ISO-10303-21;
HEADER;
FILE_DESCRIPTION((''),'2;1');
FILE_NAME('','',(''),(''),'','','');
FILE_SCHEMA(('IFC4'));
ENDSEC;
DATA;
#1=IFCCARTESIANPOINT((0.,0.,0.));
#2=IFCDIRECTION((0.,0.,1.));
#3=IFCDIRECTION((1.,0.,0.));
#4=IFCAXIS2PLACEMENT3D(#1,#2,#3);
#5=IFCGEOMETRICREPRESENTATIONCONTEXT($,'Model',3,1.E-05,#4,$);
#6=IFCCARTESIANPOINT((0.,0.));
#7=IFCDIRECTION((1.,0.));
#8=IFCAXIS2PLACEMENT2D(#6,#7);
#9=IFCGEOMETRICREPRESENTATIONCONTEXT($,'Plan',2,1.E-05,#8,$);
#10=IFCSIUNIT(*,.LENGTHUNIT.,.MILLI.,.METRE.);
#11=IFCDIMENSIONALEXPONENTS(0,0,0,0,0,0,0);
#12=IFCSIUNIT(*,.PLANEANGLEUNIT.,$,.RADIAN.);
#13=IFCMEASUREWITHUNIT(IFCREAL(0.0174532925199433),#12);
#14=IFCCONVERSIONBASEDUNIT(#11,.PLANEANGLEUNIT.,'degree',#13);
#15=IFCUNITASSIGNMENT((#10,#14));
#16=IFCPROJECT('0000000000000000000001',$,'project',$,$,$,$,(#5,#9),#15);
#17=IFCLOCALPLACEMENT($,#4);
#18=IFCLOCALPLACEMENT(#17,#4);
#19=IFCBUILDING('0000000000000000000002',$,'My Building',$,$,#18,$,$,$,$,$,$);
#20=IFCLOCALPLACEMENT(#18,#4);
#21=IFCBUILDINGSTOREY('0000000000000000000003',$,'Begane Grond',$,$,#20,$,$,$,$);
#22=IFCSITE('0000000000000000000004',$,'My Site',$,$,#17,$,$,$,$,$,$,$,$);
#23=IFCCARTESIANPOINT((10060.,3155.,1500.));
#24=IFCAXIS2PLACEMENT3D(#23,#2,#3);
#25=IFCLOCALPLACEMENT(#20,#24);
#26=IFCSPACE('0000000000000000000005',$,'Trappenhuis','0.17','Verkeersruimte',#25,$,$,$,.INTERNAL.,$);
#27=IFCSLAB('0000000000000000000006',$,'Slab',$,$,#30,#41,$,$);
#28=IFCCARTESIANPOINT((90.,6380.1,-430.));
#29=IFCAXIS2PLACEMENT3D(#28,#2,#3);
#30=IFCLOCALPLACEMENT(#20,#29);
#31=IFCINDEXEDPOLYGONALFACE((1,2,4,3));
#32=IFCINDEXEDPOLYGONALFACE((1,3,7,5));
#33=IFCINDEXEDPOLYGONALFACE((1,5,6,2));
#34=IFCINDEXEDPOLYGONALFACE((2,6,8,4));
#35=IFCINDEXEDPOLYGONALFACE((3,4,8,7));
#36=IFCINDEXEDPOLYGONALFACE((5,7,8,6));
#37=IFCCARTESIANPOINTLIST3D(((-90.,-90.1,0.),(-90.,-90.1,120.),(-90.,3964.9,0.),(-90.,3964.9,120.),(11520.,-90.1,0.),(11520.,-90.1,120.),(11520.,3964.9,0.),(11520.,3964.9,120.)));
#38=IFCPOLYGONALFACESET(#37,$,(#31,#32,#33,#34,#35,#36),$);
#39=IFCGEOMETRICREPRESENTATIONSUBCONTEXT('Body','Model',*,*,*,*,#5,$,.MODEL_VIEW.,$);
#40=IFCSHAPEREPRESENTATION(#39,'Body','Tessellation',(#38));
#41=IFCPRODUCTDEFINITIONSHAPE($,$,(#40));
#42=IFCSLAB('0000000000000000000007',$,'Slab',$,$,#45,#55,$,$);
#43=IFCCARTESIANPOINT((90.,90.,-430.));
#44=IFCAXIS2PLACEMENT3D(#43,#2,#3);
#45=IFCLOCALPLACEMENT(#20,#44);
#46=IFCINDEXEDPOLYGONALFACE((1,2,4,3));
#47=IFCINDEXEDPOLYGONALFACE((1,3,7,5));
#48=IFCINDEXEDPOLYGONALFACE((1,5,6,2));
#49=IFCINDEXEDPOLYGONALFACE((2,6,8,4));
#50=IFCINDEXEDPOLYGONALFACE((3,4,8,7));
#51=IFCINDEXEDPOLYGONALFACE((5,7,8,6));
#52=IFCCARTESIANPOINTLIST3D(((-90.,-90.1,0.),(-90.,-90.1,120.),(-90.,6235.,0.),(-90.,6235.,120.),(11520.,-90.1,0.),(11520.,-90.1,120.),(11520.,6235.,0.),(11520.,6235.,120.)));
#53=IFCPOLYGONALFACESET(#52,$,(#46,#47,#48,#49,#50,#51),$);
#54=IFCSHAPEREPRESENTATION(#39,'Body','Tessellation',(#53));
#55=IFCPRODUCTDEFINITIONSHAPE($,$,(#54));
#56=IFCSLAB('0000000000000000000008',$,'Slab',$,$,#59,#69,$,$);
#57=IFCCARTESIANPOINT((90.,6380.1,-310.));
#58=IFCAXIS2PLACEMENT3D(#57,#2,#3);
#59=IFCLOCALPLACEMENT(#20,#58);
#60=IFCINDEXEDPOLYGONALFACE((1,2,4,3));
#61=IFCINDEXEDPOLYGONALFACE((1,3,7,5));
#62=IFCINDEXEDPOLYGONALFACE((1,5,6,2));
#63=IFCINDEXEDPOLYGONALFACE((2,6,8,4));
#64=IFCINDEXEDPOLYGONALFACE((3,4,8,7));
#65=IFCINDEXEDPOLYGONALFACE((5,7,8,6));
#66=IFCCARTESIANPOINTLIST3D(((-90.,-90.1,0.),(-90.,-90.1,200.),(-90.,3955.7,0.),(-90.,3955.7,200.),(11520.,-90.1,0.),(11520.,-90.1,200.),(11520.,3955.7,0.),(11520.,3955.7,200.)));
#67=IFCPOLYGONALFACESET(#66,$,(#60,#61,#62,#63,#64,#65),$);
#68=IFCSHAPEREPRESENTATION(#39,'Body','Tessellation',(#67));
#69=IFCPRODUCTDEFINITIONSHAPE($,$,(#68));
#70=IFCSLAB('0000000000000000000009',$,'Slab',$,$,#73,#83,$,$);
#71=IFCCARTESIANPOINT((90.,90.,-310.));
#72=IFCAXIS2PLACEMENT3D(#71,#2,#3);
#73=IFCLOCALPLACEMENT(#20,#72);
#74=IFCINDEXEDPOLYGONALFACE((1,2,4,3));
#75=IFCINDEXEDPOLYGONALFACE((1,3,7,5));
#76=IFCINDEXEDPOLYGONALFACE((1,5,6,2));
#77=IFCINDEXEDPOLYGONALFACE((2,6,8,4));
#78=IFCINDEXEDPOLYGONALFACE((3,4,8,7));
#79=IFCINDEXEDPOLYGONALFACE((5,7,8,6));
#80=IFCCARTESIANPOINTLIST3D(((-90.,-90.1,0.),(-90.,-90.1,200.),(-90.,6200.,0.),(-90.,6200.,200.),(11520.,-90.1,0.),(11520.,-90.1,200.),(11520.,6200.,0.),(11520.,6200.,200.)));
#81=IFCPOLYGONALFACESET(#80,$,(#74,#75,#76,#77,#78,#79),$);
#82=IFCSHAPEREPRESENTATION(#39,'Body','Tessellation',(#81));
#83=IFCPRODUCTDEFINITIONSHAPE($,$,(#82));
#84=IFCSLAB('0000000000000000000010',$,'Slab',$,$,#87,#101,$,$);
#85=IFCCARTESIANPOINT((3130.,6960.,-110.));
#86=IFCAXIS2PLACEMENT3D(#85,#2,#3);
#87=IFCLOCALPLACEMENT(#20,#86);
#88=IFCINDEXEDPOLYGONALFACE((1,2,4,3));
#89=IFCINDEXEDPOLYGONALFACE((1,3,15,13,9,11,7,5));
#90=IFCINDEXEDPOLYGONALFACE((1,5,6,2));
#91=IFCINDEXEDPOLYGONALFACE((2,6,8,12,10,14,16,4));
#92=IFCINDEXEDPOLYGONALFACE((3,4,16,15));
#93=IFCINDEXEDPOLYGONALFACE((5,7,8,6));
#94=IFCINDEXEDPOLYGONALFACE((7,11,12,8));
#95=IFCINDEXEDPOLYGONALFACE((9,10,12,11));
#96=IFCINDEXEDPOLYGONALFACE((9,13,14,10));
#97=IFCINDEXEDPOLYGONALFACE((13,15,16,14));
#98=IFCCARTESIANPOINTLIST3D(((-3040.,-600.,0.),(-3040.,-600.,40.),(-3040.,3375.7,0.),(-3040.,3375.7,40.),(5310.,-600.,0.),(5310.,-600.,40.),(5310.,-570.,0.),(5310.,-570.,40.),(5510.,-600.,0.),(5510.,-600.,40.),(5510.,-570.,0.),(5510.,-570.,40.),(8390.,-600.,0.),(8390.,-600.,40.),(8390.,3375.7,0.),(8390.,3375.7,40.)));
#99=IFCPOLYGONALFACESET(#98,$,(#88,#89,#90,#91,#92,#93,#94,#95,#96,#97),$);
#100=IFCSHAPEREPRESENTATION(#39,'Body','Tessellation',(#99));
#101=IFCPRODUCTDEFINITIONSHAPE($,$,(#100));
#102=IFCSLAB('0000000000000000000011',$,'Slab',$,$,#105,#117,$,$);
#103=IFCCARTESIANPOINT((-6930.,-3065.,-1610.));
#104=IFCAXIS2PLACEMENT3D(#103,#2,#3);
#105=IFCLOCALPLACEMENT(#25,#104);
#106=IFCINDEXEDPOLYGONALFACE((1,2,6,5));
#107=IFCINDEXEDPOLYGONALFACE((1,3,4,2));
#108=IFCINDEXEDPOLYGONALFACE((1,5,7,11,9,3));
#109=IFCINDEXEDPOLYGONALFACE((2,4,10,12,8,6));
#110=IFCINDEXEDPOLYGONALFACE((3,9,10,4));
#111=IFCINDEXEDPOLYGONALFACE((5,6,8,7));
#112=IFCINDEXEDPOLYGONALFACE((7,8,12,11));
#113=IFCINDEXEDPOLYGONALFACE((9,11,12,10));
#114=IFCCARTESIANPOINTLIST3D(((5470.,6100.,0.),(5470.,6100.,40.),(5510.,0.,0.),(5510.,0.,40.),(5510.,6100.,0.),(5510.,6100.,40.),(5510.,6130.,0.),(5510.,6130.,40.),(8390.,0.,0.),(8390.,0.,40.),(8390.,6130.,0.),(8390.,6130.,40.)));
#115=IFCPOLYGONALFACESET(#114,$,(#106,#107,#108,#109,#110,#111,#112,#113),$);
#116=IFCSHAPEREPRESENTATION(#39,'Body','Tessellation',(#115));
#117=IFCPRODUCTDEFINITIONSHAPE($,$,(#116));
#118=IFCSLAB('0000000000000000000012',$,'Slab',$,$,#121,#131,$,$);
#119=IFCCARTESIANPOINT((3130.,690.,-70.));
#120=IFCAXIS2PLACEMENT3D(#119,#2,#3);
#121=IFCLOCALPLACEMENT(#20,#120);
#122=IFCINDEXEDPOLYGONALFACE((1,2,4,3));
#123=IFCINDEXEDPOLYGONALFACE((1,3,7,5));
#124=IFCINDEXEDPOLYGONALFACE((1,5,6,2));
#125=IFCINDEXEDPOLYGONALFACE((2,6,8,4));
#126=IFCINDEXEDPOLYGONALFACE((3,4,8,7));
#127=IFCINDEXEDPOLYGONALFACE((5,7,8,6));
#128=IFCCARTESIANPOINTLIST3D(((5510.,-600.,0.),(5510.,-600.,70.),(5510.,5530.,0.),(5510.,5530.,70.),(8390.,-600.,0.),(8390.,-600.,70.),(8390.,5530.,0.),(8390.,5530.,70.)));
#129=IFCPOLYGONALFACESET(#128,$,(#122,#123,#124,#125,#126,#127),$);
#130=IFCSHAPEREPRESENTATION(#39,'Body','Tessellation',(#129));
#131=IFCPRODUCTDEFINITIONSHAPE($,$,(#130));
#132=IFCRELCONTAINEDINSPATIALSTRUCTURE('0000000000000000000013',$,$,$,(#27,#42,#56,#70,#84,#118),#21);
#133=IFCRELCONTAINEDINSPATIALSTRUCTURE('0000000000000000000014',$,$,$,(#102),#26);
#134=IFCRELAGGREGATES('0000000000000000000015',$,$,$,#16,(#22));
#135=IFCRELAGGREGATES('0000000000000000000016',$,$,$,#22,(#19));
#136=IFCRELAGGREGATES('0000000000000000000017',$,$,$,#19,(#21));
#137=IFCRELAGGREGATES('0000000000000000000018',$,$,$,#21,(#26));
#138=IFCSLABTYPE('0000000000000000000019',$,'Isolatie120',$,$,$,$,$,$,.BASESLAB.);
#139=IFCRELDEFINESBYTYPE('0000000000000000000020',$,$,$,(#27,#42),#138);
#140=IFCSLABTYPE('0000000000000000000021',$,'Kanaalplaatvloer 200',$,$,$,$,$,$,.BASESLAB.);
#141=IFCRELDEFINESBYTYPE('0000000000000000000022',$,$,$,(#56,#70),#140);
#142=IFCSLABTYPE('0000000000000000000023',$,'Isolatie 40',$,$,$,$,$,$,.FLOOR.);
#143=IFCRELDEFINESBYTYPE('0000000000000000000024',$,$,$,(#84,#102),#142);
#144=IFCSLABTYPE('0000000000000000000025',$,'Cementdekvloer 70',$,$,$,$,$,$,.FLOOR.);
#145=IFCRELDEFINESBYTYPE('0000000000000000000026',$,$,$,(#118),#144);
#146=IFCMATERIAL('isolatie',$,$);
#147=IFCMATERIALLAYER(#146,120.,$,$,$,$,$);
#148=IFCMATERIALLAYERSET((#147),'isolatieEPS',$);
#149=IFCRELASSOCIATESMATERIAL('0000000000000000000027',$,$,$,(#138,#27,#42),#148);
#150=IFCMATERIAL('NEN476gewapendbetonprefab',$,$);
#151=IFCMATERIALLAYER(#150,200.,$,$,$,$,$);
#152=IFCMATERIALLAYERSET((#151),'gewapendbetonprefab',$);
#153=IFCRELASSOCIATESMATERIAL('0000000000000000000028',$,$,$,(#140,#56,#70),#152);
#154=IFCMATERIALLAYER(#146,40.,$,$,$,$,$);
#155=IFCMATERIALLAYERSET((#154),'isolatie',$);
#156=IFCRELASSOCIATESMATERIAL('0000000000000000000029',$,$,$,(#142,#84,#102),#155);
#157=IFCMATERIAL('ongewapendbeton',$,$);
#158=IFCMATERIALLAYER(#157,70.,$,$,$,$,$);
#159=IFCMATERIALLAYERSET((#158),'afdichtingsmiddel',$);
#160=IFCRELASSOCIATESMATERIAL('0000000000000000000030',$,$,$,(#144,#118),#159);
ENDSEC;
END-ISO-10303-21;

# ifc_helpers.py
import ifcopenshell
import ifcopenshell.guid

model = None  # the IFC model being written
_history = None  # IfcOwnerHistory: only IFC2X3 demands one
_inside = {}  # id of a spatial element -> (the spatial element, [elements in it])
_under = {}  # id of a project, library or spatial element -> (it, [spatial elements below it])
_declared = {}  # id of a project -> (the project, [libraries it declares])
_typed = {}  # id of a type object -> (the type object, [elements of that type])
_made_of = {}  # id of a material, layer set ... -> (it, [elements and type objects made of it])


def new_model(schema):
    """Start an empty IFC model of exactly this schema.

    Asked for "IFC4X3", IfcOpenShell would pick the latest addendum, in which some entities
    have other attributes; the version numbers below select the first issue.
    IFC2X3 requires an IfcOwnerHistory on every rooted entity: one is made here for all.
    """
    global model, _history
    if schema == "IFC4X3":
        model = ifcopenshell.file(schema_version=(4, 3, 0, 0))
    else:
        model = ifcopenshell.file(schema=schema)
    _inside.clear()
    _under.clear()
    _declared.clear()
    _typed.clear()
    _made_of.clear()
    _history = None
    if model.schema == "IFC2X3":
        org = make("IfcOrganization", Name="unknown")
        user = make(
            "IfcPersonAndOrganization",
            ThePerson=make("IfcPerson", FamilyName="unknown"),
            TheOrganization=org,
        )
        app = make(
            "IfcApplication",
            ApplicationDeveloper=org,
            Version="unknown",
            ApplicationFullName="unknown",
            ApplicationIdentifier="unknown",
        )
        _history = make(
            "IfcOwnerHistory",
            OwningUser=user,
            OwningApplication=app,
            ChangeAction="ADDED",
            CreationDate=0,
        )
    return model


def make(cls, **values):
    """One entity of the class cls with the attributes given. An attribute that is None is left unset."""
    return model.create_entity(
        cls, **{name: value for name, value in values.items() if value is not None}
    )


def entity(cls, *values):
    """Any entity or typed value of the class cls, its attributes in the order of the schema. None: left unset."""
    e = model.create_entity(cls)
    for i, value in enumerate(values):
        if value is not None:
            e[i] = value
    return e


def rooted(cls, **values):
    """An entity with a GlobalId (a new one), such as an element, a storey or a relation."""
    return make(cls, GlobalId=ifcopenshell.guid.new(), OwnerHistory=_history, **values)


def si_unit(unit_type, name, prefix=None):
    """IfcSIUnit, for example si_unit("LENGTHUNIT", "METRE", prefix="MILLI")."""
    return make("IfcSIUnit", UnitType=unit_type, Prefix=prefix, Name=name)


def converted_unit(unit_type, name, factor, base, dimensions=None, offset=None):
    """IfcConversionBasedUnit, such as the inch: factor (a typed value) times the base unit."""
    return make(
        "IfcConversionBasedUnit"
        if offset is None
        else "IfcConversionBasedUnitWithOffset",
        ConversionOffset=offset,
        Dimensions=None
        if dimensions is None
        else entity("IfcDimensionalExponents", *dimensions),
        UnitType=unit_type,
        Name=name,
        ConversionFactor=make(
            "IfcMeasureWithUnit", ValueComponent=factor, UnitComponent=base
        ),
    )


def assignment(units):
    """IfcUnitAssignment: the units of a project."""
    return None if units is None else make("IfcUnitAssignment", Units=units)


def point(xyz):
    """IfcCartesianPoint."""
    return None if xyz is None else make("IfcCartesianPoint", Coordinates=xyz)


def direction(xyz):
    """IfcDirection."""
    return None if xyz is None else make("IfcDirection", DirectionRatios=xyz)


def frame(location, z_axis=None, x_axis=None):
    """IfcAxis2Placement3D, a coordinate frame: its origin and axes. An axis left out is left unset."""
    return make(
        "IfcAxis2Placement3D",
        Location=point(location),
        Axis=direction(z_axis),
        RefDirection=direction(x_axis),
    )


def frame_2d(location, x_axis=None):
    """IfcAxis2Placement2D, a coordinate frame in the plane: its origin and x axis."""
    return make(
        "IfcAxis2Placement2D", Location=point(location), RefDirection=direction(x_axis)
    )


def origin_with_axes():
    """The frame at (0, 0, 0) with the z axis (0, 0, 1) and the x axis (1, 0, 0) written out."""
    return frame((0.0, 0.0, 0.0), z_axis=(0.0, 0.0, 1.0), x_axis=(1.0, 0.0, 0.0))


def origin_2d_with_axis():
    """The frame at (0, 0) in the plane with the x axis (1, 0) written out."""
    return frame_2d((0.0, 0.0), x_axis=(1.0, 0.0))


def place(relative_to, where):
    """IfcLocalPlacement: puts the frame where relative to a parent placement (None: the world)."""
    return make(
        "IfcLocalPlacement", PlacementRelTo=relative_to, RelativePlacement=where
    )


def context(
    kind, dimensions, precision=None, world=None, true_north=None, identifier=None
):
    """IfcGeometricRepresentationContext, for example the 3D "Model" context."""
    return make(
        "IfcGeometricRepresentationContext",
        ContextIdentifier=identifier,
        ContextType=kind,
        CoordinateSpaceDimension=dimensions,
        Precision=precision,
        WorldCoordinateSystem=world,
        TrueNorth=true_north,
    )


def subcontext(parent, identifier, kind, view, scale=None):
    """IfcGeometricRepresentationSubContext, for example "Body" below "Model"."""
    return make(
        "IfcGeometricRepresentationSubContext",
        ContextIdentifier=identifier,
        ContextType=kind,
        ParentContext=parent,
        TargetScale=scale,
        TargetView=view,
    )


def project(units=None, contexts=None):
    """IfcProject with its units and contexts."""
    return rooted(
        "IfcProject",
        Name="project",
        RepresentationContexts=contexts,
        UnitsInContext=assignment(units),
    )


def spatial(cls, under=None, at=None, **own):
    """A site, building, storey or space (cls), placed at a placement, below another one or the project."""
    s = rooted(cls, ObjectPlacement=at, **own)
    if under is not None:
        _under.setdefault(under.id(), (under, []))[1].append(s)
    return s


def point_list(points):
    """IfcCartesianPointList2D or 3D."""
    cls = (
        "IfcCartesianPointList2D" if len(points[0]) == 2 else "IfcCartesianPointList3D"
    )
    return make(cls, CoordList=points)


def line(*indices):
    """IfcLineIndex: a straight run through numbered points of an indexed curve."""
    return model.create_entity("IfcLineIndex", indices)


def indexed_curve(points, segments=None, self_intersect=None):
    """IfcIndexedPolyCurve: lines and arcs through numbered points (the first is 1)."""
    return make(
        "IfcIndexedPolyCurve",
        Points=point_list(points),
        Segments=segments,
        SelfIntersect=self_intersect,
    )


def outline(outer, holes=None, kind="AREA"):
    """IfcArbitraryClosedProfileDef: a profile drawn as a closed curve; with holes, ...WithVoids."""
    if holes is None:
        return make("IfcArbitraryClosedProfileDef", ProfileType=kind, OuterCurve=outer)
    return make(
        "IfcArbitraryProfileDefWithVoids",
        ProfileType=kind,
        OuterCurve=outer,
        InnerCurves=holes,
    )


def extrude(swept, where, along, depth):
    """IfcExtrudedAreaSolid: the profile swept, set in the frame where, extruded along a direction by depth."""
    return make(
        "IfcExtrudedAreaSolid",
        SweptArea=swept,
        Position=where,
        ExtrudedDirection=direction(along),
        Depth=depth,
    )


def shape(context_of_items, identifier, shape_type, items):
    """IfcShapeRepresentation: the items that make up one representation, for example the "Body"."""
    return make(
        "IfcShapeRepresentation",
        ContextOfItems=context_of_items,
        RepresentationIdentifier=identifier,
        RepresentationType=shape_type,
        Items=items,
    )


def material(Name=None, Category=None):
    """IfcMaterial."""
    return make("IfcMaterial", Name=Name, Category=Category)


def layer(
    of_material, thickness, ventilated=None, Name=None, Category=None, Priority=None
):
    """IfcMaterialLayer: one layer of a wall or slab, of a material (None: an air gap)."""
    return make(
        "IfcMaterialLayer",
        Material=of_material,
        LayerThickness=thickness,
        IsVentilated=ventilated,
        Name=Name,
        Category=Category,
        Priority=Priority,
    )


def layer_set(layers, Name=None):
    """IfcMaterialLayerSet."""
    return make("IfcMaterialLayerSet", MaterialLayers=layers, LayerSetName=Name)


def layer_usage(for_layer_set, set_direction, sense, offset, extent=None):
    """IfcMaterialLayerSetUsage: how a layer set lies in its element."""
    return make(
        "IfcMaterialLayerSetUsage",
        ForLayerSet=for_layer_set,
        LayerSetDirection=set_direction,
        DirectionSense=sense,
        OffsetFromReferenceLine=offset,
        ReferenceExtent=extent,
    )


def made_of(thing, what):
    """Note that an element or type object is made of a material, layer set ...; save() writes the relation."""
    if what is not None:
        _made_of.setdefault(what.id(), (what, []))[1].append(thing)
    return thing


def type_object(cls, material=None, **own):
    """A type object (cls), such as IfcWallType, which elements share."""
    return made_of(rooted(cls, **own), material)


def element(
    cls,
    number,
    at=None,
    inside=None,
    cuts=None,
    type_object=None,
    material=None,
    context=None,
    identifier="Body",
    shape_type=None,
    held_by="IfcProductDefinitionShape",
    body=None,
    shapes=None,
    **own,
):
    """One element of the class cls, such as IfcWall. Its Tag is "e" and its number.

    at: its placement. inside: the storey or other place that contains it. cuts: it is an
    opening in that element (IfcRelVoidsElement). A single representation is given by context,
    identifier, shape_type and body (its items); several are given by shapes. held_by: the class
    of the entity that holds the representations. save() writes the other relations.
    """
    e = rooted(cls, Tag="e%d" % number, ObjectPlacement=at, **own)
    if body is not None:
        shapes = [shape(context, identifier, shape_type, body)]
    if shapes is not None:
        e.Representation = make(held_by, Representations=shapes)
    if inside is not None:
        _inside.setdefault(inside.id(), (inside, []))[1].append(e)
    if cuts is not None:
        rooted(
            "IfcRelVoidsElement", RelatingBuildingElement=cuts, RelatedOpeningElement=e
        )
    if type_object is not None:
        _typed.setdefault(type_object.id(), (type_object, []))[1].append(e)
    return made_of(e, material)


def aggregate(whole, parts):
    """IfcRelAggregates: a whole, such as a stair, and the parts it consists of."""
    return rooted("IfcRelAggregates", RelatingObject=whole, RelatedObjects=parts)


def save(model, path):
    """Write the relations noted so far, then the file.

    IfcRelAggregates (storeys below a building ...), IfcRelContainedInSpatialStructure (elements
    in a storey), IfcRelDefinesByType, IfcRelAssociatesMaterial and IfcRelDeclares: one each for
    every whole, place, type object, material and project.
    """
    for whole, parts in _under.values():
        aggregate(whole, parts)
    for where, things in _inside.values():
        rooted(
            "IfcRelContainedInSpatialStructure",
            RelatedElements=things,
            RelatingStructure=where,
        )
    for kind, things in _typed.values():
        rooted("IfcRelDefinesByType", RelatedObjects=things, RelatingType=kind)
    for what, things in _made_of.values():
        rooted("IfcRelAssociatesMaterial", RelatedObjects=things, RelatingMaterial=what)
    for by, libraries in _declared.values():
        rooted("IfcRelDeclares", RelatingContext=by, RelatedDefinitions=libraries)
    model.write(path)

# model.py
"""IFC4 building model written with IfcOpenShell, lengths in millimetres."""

from ifc_helpers import new_model, entity, si_unit, converted_unit, frame, origin_with_axes, origin_2d_with_axis, place, context, subcontext, project, spatial, line, indexed_curve, outline, extrude, material, layer, layer_set, layer_usage, type_object, element, save


model = new_model("IFC4")

# Units and contexts
model_context = context("Model", 3, precision=1e-05, world=origin_with_axes())
plan_context = context("Plan", 2, precision=1e-05, world=origin_2d_with_axis())
body_context = subcontext(model_context, "Body", "Model", "MODEL_VIEW")
ifc_project = project(units=[si_unit("LENGTHUNIT", "METRE", prefix="MILLI"), converted_unit("PLANEANGLEUNIT", "degree", entity("IfcReal", 0.0174532925199433), si_unit("PLANEANGLEUNIT", "RADIAN"), dimensions=[0, 0, 0, 0, 0, 0, 0])], contexts=[model_context, plan_context])

# Site, building, storey
site_placement = place(None, origin_with_axes())
site = spatial("IfcSite", under=ifc_project, at=site_placement, Name="My Site")
building_placement = place(site_placement, origin_with_axes())
building = spatial("IfcBuilding", under=site, at=building_placement, Name="My Building")
storey_placement = place(building_placement, origin_with_axes())
storey = spatial("IfcBuildingStorey", under=building, at=storey_placement, Name="Begane Grond")

# Shared definitions
ifc_material_1 = material(Name="NEN476gewapendbetonprefab")

# Slabs
ifc_material_2 = material(Name="isolatie")
ifc_layer_1 = layer(ifc_material_2, 120.0)
ifc_layer_set_1 = layer_set([ifc_layer_1], Name="isolatieEPS")
ifc_layer_usage_1 = layer_usage(ifc_layer_set_1, "AXIS3", "POSITIVE", 0.0)
slab_type_1 = type_object("IfcSlabType", Name="Isolatie120", PredefinedType="BASESLAB", material=ifc_layer_set_1)
slab_1_placement = place(storey_placement, frame((90.0, 6380.1, -430.0), z_axis=(0.0, 0.0, 1.0), x_axis=(1.0, 0.0, 0.0)))
element("IfcSlab", 1, at=slab_1_placement, inside=storey, type_object=slab_type_1, material=ifc_layer_usage_1, Name="Slab", context=body_context, shape_type="SweptSolid", body=[
    extrude(outline(indexed_curve([(11520.0, 3964.9), (-90.0, 3964.9), (-90.0, -90.1), (11520.0, -90.1)], segments=[line(3, 2), line(2, 1), line(1, 4), line(4, 3)], self_intersect=False)), None, (0.0, 0.0, 1.0), 120.0),
])
ifc_layer_usage_2 = layer_usage(ifc_layer_set_1, "AXIS3", "POSITIVE", 0.0)
slab_2_placement = place(storey_placement, frame((90.0, 90.0, -430.0), z_axis=(0.0, 0.0, 1.0), x_axis=(1.0, 0.0, 0.0)))
element("IfcSlab", 2, at=slab_2_placement, inside=storey, type_object=slab_type_1, material=ifc_layer_usage_2, Name="Slab", context=body_context, shape_type="SweptSolid", body=[
    extrude(outline(indexed_curve([(11520.0, 6235.0), (-90.0, 6235.0), (-90.0, -90.1), (11520.0, -90.1)], segments=[line(4, 1), line(1, 2), line(2, 3), line(3, 4)], self_intersect=False)), None, (0.0, 0.0, 1.0), 120.0),
])
ifc_layer_2 = layer(ifc_material_1, 200.0)
ifc_layer_set_2 = layer_set([ifc_layer_2], Name="gewapendbetonprefab")
ifc_layer_usage_3 = layer_usage(ifc_layer_set_2, "AXIS3", "POSITIVE", 0.0)
slab_type_2 = type_object("IfcSlabType", Name="Kanaalplaatvloer 200", PredefinedType="BASESLAB", material=ifc_layer_set_2)
slab_3_placement = place(storey_placement, frame((90.0, 6380.1, -310.0), z_axis=(0.0, 0.0, 1.0), x_axis=(1.0, 0.0, 0.0)))
element("IfcSlab", 3, at=slab_3_placement, inside=storey, type_object=slab_type_2, material=ifc_layer_usage_3, Name="Slab", context=body_context, shape_type="SweptSolid", body=[
    extrude(outline(indexed_curve([(11520.0, 3955.7), (-90.0, 3955.7), (-90.0, -90.1), (11520.0, -90.1)], segments=[line(4, 1), line(1, 2), line(2, 3), line(3, 4)], self_intersect=False)), None, (0.0, 0.0, 1.0), 200.0),
])
ifc_layer_usage_4 = layer_usage(ifc_layer_set_2, "AXIS3", "POSITIVE", 0.0)
slab_4_placement = place(storey_placement, frame((90.0, 90.0, -310.0), z_axis=(0.0, 0.0, 1.0), x_axis=(1.0, 0.0, 0.0)))
element("IfcSlab", 4, at=slab_4_placement, inside=storey, type_object=slab_type_2, material=ifc_layer_usage_4, Name="Slab", context=body_context, shape_type="SweptSolid", body=[
    extrude(outline(indexed_curve([(-90.0, -90.1), (11520.0, -90.1), (11520.0, 6200.0), (-90.0, 6200.0)], segments=[line(4, 1), line(1, 2), line(2, 3), line(3, 4)], self_intersect=False)), None, (0.0, 0.0, 1.0), 200.0),
])
ifc_layer_3 = layer(ifc_material_2, 40.0)
ifc_layer_set_3 = layer_set([ifc_layer_3], Name="isolatie")
ifc_layer_usage_5 = layer_usage(ifc_layer_set_3, "AXIS3", "POSITIVE", 0.0)
slab_type_3 = type_object("IfcSlabType", Name="Isolatie 40", PredefinedType="FLOOR", material=ifc_layer_set_3)
slab_5_placement = place(storey_placement, frame((3130.0, 6960.0, -110.0), z_axis=(0.0, 0.0, 1.0), x_axis=(1.0, 0.0, 0.0)))
element("IfcSlab", 5, at=slab_5_placement, inside=storey, type_object=slab_type_3, material=ifc_layer_usage_5, Name="Slab", context=body_context, shape_type="SweptSolid", body=[
    extrude(outline(indexed_curve([(5310.0, -570.0), (5510.0, -570.0), (5510.0, -600.0), (8390.0, -600.0), (8390.0, 3375.7), (-3040.0, 3375.7), (-3040.0, -600.0), (5310.0, -600.0)], segments=[line(5, 6), line(6, 7), line(7, 8), line(8, 1), line(1, 2), line(2, 3), line(3, 4), line(4, 5)], self_intersect=False)), None, (0.0, 0.0, 1.0), 40.0),
])

# Shared definitions
space_1_placement = place(storey_placement, frame((10060.0, 3155.0, 1500.0), z_axis=(0.0, 0.0, 1.0), x_axis=(1.0, 0.0, 0.0)))
space_1 = spatial("IfcSpace", under=storey, at=space_1_placement, Name="Trappenhuis", Description="0.17", ObjectType="Verkeersruimte", PredefinedType="INTERNAL")

# Slabs
ifc_layer_usage_6 = layer_usage(ifc_layer_set_3, "AXIS3", "POSITIVE", 0.0)
slab_6_placement = place(space_1_placement, frame((-6930.0, -3065.0, -1610.0), z_axis=(0.0, 0.0, 1.0), x_axis=(1.0, 0.0, 0.0)))
element("IfcSlab", 6, at=slab_6_placement, inside=space_1, type_object=slab_type_3, material=ifc_layer_usage_6, Name="Slab", context=body_context, shape_type="SweptSolid", body=[
    extrude(outline(indexed_curve([(8390.0, 0.0), (5510.0, 0.0), (5510.0, 6130.0), (5470.0, 6100.0), (5510.0, 6100.0), (8390.0, 6130.0)], segments=[line(2, 1), line(1, 6), line(6, 3), line(3, 5), line(5, 4), line(4, 2)], self_intersect=False)), None, (0.0, 0.0, 1.0), 40.0),
])
ifc_material_3 = material(Name="ongewapendbeton")
ifc_layer_4 = layer(ifc_material_3, 70.0)
ifc_layer_set_4 = layer_set([ifc_layer_4], Name="afdichtingsmiddel")
ifc_layer_usage_7 = layer_usage(ifc_layer_set_4, "AXIS3", "POSITIVE", 0.0)
slab_type_4 = type_object("IfcSlabType", Name="Cementdekvloer 70", PredefinedType="FLOOR", material=ifc_layer_set_4)
slab_7_placement = place(storey_placement, frame((3130.0, 690.0, -70.0), z_axis=(0.0, 0.0, 1.0), x_axis=(1.0, 0.0, 0.0)))
element("IfcSlab", 7, at=slab_7_placement, inside=storey, type_object=slab_type_4, material=ifc_layer_usage_7, Name="Slab", context=body_context, shape_type="SweptSolid", body=[
    extrude(outline(indexed_curve([(5510.0, -600.0), (5510.0, 5530.0), (8390.0, 5530.0), (8390.0, -600.0)], segments=[line(4, 1), line(1, 2), line(2, 3), line(3, 4)], self_intersect=False)), None, (0.0, 0.0, 1.0), 70.0),
])

save(model, "model.ifc")
